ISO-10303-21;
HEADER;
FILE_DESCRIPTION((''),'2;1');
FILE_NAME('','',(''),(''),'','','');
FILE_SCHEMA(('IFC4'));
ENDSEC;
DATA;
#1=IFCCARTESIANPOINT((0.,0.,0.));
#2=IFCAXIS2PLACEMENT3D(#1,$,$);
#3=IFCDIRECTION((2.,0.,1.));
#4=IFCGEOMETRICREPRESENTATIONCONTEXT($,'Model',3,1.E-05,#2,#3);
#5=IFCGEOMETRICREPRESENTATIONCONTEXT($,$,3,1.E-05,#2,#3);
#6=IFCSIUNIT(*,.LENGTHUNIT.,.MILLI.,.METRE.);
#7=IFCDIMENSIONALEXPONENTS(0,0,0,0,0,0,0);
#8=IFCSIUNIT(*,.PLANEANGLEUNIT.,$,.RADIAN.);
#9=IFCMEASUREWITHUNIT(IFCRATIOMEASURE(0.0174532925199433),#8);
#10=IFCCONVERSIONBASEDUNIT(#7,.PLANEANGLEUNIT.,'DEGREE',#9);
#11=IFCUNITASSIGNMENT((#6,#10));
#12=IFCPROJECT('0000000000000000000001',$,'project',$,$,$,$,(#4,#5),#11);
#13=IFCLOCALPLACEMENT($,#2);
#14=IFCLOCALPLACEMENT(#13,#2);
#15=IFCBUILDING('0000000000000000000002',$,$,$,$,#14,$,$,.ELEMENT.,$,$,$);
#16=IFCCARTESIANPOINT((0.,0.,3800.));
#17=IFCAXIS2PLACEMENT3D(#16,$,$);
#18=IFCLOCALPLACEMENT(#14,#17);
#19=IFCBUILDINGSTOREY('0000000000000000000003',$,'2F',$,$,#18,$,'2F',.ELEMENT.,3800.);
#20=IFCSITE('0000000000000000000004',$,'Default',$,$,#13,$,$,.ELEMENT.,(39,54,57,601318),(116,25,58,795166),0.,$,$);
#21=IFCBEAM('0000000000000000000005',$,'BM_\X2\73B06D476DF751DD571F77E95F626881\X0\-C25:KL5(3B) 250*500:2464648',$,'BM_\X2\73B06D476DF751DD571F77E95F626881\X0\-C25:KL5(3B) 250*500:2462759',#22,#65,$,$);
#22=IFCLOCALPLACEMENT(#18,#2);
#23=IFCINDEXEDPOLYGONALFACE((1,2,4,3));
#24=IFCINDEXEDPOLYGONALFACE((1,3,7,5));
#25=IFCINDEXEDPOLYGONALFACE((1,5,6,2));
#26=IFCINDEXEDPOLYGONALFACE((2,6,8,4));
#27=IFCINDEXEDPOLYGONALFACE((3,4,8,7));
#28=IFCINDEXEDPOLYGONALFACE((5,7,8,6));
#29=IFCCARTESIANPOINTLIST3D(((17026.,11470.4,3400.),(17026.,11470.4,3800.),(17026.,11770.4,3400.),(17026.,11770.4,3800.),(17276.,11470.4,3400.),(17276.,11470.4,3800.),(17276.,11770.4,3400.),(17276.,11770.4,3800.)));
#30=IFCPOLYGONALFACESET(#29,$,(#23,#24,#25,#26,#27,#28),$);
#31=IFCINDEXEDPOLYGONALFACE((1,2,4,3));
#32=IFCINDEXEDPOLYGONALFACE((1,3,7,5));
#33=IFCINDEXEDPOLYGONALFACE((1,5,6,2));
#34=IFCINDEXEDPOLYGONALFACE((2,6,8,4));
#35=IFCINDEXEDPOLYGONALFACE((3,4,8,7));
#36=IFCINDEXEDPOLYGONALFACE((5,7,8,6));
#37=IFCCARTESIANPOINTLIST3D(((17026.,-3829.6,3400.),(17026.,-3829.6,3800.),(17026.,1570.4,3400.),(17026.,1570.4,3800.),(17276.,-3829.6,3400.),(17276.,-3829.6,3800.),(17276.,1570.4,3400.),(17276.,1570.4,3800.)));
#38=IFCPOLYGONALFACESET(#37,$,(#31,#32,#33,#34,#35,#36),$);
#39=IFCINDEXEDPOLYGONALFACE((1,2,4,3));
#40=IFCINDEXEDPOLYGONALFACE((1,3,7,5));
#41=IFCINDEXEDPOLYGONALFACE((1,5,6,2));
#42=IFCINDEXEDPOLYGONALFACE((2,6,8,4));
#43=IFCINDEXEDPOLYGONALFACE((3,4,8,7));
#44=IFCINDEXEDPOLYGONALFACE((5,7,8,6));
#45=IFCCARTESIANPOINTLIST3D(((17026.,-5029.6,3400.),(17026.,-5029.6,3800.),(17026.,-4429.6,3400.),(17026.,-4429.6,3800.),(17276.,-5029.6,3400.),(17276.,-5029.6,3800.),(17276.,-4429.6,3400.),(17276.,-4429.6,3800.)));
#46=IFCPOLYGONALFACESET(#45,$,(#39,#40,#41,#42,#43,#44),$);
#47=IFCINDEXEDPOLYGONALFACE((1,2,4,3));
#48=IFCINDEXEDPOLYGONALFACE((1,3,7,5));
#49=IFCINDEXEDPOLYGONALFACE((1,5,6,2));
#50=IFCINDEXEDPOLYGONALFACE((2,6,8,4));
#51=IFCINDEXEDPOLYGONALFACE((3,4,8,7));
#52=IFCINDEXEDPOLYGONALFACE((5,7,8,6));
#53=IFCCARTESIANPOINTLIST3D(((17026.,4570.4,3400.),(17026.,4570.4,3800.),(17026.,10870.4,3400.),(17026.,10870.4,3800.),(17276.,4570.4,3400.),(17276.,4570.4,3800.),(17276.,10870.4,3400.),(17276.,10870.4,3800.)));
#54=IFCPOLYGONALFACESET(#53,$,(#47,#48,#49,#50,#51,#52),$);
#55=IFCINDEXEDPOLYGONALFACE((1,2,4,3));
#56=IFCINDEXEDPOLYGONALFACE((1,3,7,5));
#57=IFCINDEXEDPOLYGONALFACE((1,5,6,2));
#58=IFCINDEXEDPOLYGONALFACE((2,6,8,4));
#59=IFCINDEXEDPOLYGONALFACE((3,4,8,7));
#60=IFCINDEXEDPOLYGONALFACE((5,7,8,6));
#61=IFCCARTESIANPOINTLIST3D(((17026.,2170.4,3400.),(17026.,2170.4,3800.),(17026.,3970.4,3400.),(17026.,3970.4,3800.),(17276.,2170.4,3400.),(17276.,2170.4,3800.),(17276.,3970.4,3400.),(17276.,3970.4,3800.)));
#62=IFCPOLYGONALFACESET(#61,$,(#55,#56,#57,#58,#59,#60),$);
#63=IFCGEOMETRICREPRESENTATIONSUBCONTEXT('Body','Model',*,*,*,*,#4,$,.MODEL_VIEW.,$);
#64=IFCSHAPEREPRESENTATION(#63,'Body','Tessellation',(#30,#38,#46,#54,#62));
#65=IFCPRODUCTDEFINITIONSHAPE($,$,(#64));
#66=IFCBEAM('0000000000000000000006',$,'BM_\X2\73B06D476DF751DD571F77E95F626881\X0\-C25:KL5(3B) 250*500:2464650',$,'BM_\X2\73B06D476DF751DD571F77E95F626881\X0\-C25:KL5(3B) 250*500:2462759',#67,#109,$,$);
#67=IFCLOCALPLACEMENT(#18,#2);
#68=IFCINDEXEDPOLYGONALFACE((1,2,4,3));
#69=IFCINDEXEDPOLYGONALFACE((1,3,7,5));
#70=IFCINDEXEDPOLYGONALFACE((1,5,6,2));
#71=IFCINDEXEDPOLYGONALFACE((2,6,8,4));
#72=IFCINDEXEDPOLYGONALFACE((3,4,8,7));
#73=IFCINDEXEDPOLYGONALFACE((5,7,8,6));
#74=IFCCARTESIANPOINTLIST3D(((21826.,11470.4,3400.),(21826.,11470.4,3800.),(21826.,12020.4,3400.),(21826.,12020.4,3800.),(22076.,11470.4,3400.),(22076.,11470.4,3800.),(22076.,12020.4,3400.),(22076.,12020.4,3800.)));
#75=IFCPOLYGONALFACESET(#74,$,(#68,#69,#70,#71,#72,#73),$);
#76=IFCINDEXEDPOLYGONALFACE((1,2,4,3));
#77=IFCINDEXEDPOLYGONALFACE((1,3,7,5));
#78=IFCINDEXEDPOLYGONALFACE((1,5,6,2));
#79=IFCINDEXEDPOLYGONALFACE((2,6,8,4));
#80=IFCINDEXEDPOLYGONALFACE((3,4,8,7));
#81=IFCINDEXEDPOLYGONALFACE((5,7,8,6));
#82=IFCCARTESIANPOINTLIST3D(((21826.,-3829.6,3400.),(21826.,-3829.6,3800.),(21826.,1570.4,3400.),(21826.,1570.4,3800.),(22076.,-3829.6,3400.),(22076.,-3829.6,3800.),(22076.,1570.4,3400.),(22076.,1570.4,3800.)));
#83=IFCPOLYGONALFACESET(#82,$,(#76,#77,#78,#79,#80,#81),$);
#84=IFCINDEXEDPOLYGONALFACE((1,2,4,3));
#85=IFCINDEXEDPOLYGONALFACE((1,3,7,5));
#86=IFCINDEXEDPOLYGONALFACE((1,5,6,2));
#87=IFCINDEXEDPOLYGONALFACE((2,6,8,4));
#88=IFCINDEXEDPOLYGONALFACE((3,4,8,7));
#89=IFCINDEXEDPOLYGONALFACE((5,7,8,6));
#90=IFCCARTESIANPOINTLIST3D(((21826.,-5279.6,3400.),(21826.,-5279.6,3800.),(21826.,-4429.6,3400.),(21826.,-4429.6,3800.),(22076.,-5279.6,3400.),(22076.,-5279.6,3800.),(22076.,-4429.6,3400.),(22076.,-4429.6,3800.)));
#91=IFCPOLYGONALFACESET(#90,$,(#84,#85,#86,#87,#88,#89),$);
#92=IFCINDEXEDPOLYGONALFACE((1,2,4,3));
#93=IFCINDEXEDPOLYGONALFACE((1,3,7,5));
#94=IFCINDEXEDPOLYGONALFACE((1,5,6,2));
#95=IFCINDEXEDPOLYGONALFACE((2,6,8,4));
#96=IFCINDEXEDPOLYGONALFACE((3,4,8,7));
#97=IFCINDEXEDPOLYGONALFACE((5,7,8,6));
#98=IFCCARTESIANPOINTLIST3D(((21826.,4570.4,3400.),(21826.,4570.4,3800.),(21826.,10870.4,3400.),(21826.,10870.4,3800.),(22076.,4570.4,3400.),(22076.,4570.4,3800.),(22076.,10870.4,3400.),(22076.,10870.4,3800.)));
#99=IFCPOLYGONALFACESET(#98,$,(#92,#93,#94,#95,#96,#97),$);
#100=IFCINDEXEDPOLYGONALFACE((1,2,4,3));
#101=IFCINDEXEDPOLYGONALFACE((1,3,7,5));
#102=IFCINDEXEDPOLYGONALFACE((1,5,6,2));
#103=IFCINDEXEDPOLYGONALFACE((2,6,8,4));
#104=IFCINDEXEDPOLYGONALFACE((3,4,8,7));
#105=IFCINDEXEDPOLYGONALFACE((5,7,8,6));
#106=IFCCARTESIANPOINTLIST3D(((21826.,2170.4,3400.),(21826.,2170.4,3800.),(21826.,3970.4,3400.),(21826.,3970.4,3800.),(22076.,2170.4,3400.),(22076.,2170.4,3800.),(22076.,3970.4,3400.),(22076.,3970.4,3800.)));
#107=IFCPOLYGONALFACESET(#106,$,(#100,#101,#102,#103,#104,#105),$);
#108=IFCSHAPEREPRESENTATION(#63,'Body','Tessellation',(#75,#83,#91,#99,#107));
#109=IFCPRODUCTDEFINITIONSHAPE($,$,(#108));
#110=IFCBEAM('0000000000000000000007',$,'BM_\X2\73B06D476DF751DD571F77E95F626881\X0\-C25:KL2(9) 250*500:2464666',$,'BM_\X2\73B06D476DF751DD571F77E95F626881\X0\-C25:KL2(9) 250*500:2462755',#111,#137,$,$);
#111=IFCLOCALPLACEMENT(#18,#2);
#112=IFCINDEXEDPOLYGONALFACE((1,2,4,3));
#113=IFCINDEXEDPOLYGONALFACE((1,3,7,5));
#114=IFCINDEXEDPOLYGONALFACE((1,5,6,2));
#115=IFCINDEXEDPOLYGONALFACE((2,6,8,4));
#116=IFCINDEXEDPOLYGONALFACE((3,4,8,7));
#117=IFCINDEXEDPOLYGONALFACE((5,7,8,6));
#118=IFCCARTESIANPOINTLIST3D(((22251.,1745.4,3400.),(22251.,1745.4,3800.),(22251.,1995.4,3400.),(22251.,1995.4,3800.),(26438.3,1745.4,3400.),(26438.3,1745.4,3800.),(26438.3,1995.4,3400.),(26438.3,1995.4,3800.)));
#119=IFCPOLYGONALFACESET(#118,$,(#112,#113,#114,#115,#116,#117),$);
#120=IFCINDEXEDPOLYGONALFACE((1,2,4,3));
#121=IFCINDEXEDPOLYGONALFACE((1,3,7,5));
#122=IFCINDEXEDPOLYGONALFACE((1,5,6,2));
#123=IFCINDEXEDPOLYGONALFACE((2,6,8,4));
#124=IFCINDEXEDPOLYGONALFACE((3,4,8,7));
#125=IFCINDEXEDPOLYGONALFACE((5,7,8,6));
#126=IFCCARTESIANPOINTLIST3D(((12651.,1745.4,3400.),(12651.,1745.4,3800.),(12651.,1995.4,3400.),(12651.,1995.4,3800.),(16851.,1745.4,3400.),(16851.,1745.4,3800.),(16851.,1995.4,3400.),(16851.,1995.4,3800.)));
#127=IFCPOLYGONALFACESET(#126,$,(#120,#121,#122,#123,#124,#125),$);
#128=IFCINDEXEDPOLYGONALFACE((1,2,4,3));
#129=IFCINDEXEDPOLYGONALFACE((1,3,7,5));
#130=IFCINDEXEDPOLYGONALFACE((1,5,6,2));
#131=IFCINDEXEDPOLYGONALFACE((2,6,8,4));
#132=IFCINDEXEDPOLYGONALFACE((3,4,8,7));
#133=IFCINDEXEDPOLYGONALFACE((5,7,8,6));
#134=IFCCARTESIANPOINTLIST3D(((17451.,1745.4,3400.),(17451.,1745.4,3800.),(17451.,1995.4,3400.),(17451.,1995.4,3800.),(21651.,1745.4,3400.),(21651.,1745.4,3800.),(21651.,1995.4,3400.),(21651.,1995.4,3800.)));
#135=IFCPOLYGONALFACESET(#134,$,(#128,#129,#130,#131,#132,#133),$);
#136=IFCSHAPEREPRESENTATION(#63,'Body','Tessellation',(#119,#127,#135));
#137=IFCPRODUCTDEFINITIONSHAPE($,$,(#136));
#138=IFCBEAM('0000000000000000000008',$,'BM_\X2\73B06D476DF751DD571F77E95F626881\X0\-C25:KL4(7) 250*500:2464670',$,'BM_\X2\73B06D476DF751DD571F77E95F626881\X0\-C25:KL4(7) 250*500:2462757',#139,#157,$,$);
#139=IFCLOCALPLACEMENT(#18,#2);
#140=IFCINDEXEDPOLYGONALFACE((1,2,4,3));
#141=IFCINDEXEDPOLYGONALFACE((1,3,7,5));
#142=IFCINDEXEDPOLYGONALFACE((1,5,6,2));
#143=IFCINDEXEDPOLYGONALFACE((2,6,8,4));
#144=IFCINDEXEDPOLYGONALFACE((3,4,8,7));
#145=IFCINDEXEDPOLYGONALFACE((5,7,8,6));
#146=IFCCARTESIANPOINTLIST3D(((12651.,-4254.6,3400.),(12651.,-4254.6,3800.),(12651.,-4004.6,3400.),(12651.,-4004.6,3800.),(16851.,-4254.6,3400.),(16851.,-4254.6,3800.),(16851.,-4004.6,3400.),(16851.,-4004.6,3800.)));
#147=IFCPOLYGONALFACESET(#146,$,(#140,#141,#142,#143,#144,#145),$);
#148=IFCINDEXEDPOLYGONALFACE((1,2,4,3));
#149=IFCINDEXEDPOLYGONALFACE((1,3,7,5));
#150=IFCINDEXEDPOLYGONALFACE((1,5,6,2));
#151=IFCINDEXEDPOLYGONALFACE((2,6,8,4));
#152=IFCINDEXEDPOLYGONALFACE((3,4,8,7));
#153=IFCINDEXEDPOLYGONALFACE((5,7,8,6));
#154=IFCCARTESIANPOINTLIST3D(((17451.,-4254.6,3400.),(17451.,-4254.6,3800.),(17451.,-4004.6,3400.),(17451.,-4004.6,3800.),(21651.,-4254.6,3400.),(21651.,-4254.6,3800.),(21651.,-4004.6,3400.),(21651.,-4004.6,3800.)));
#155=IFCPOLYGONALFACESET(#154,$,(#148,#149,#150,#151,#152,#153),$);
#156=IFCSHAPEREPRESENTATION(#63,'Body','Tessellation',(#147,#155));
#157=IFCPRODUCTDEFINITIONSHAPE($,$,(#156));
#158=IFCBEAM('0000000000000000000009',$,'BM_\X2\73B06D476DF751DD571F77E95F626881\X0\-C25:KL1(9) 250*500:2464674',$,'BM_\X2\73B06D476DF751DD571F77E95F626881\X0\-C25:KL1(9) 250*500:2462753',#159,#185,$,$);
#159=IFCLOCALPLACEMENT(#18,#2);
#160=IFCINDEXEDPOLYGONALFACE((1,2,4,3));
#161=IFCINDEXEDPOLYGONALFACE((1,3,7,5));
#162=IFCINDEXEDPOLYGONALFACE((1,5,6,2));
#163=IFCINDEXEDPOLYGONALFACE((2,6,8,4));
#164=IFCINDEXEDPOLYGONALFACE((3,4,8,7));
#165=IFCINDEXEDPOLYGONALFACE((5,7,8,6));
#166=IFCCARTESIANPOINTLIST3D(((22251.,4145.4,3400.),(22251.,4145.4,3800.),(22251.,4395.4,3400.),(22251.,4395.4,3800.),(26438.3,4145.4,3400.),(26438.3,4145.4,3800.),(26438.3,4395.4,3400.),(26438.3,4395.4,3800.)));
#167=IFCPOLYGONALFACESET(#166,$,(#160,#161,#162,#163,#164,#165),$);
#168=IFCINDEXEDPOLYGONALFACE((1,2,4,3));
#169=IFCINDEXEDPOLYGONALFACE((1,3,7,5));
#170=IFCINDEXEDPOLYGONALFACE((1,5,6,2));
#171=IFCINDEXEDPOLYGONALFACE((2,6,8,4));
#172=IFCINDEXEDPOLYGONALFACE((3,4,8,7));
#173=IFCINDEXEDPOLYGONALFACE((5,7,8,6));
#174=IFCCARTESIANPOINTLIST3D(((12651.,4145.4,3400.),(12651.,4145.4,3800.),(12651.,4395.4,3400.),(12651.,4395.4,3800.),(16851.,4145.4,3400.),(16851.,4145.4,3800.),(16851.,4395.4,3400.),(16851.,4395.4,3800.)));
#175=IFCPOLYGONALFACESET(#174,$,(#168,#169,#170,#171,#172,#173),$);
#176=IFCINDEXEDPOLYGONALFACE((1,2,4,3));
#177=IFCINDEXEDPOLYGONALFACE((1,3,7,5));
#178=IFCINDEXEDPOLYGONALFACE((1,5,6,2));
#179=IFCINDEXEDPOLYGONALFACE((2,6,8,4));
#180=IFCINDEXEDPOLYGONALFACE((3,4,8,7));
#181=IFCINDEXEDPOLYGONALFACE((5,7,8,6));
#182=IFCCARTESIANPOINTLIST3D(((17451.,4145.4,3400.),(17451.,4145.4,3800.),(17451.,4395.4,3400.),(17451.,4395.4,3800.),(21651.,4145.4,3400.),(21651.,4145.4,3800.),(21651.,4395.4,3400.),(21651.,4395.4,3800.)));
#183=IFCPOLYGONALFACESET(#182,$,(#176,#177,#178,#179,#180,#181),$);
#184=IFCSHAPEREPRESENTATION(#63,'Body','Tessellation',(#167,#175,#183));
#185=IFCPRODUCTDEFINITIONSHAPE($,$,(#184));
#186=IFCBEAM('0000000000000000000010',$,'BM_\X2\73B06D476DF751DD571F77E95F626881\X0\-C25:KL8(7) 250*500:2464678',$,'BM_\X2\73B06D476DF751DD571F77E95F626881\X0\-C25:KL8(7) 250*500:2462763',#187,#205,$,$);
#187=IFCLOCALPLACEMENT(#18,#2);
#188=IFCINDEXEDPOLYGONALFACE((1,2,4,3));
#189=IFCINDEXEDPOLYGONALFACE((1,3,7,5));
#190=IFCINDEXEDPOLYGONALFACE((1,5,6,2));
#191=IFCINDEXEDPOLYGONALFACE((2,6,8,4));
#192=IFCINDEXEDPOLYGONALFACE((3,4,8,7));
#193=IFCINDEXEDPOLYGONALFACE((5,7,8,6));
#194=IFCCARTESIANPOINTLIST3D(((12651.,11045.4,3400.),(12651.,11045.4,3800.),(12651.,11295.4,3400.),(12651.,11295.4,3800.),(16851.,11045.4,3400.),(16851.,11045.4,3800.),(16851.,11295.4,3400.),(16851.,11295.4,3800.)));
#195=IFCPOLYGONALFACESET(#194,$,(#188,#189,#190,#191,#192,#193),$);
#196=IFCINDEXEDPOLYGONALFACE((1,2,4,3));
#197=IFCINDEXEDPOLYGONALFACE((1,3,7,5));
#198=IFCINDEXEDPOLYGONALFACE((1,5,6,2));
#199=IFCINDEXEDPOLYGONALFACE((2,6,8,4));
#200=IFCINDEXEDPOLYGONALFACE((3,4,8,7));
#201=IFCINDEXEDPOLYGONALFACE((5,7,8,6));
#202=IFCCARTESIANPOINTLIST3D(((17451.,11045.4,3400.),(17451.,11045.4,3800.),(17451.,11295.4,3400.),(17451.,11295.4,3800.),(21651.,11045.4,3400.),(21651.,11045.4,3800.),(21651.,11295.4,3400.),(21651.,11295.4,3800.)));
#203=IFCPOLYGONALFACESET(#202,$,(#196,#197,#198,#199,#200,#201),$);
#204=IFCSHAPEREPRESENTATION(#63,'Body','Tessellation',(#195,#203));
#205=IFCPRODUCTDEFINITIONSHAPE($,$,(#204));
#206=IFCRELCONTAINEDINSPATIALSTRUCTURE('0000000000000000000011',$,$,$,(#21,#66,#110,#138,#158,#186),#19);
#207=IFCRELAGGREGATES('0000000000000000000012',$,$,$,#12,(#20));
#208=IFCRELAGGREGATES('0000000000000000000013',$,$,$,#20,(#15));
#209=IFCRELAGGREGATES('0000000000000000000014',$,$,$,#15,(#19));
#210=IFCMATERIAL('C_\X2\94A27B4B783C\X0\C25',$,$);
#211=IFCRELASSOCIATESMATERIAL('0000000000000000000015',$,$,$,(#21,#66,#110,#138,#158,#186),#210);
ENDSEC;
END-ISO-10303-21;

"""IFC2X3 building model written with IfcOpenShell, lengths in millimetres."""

from ifc_helpers import new_model, entity, si_unit, converted_unit, direction, frame, frame_2d, origin, place, context, subcontext, project, spatial, rectangle, extrude, material, element, save


model = new_model("IFC2X3")

# Units and contexts
model_context = context("Model", 3, precision=1e-05, world=origin(), true_north=direction((2.0, 0.0, 1.0)))
context_of_model = context(None, 3, precision=1e-05, world=origin(), true_north=direction((2.0, 0.0, 1.0)))
body_context = subcontext(model_context, "Body", "Model", "MODEL_VIEW")
ifc_project = project(units=[si_unit("LENGTHUNIT", "METRE", prefix="MILLI"), converted_unit("PLANEANGLEUNIT", "DEGREE", entity("IfcRatioMeasure", 0.0174532925199433), si_unit("PLANEANGLEUNIT", "RADIAN"), dimensions=[0, 0, 0, 0, 0, 0, 0])], contexts=[model_context, context_of_model])

# Site, building, storey
site_placement = place(None, origin())
site = spatial("IfcSite", under=ifc_project, at=site_placement, Name="Default", CompositionType="ELEMENT", RefLatitude=(39, 54, 57, 601318), RefLongitude=(116, 25, 58, 795166), RefElevation=0.0)
building_placement = place(site_placement, origin())
building = spatial("IfcBuilding", under=site, at=building_placement, CompositionType="ELEMENT")
storey_placement = place(building_placement, frame((0.0, 0.0, 3800.0)))
storey = spatial("IfcBuildingStorey", under=building, at=storey_placement, Name="2F", LongName="2F", CompositionType="ELEMENT", Elevation=3800.0)

# Beams
ifc_material_1 = material(Name="C_钢筋砼C25")
beam_1_placement = place(storey_placement, frame((17151.0, 11895.4, 3900.0), z_axis=(0.0, 0.0, 1.0), x_axis=(0.0, -1.0, 0.0)))
element("IfcBeam", 1, at=beam_1_placement, inside=storey, material=ifc_material_1, Name="BM_现浇混凝土矩形梁-C25:KL5(3B) 250*500:2464648", ObjectType="BM_现浇混凝土矩形梁-C25:KL5(3B) 250*500:2462759", context=body_context, shape_type="SweptSolid", body=[
    extrude(rectangle(XDim=400.0, YDim=250.0, at=frame_2d((0.0, 0.0), x_axis=(1.0, 0.0))), frame((125.0, 0.0, -300.0), z_axis=(1.0, 0.0, 0.0), x_axis=(0.0, 0.0, 1.0)), (0.0, 0.0, 1.0), 300.0),
    extrude(rectangle(XDim=400.0, YDim=250.0, at=frame_2d((0.0, 0.0), x_axis=(1.0, 0.0))), frame((10325.0, 0.0, -300.0), z_axis=(1.0, 0.0, 0.0), x_axis=(0.0, 0.0, 1.0)), (0.0, 0.0, 1.0), 5400.0),
    extrude(rectangle(XDim=400.0, YDim=250.0, at=frame_2d((0.0, 0.0), x_axis=(1.0, 0.0))), frame((16325.0, 0.0, -300.0), z_axis=(1.0, 0.0, 0.0), x_axis=(0.0, 0.0, 1.0)), (0.0, 0.0, 1.0), 600.0),
    extrude(rectangle(XDim=400.0, YDim=250.0, at=frame_2d((0.0, 0.0), x_axis=(1.0, 0.0))), frame((1025.0, 0.0, -300.0), z_axis=(1.0, 0.0, 0.0), x_axis=(0.0, 0.0, 1.0)), (0.0, 0.0, 1.0), 6300.0),
    extrude(rectangle(XDim=400.0, YDim=250.0, at=frame_2d((0.0, 0.0), x_axis=(1.0, 0.0))), frame((7925.0, 0.0, -300.0), z_axis=(1.0, 0.0, 0.0), x_axis=(0.0, 0.0, 1.0)), (0.0, 0.0, 1.0), 1800.0),
])
beam_2_placement = place(storey_placement, frame((21951.0, 11895.4, 3900.0), z_axis=(0.0, 0.0, 1.0), x_axis=(0.0, -1.0, 0.0)))
element("IfcBeam", 2, at=beam_2_placement, inside=storey, material=ifc_material_1, Name="BM_现浇混凝土矩形梁-C25:KL5(3B) 250*500:2464650", ObjectType="BM_现浇混凝土矩形梁-C25:KL5(3B) 250*500:2462759", context=body_context, shape_type="SweptSolid", body=[
    extrude(rectangle(XDim=400.0, YDim=250.0, at=frame_2d((0.0, 0.0), x_axis=(1.0, 0.0))), frame((-125.0, 0.0, -300.0), z_axis=(1.0, 0.0, 0.0), x_axis=(0.0, 0.0, 1.0)), (0.0, 0.0, 1.0), 550.0),
    extrude(rectangle(XDim=400.0, YDim=250.0, at=frame_2d((0.0, 0.0), x_axis=(1.0, 0.0))), frame((10325.0, 0.0, -300.0), z_axis=(1.0, 0.0, 0.0), x_axis=(0.0, 0.0, 1.0)), (0.0, 0.0, 1.0), 5400.0),
    extrude(rectangle(XDim=400.0, YDim=250.0, at=frame_2d((0.0, 0.0), x_axis=(1.0, 0.0))), frame((16325.0, 0.0, -300.0), z_axis=(1.0, 0.0, 0.0), x_axis=(0.0, 0.0, 1.0)), (0.0, 0.0, 1.0), 850.0),
    extrude(rectangle(XDim=400.0, YDim=250.0, at=frame_2d((0.0, 0.0), x_axis=(1.0, 0.0))), frame((1025.0, 0.0, -300.0), z_axis=(1.0, 0.0, 0.0), x_axis=(0.0, 0.0, 1.0)), (0.0, 0.0, 1.0), 6300.0),
    extrude(rectangle(XDim=400.0, YDim=250.0, at=frame_2d((0.0, 0.0), x_axis=(1.0, 0.0))), frame((7925.0, 0.0, -300.0), z_axis=(1.0, 0.0, 0.0), x_axis=(0.0, 0.0, 1.0)), (0.0, 0.0, 1.0), 1800.0),
])
beam_3_placement = place(storey_placement, frame((12351.0, 1870.4, 3900.0)))
element("IfcBeam", 3, at=beam_3_placement, inside=storey, material=ifc_material_1, Name="BM_现浇混凝土矩形梁-C25:KL2(9) 250*500:2464666", ObjectType="BM_现浇混凝土矩形梁-C25:KL2(9) 250*500:2462755", context=body_context, shape_type="SweptSolid", body=[
    extrude(rectangle(XDim=400.0, YDim=250.0, at=frame_2d((0.0, 0.0), x_axis=(1.0, 0.0))), frame((9900.0, 0.0, -300.0), z_axis=(1.0, 0.0, 0.0), x_axis=(0.0, 0.0, 1.0)), (0.0, 0.0, 1.0), 4187.3),
    extrude(rectangle(XDim=400.0, YDim=250.0, at=frame_2d((0.0, 0.0), x_axis=(1.0, 0.0))), frame((300.0, 0.0, -300.0), z_axis=(1.0, 0.0, 0.0), x_axis=(0.0, 0.0, 1.0)), (0.0, 0.0, 1.0), 4200.0),
    extrude(rectangle(XDim=400.0, YDim=250.0, at=frame_2d((0.0, 0.0), x_axis=(1.0, 0.0))), frame((5100.0, 0.0, -300.0), z_axis=(1.0, 0.0, 0.0), x_axis=(0.0, 0.0, 1.0)), (0.0, 0.0, 1.0), 4200.0),
])
beam_4_placement = place(storey_placement, frame((12351.0, -4129.6, 3900.0)))
element("IfcBeam", 4, at=beam_4_placement, inside=storey, material=ifc_material_1, Name="BM_现浇混凝土矩形梁-C25:KL4(7) 250*500:2464670", ObjectType="BM_现浇混凝土矩形梁-C25:KL4(7) 250*500:2462757", context=body_context, shape_type="SweptSolid", body=[
    extrude(rectangle(XDim=400.0, YDim=250.0, at=frame_2d((0.0, 0.0), x_axis=(1.0, 0.0))), frame((300.0, 0.0, -300.0), z_axis=(1.0, 0.0, 0.0), x_axis=(0.0, 0.0, 1.0)), (0.0, 0.0, 1.0), 4200.0),
    extrude(rectangle(XDim=400.0, YDim=250.0, at=frame_2d((0.0, 0.0), x_axis=(1.0, 0.0))), frame((5100.0, 0.0, -300.0), z_axis=(1.0, 0.0, 0.0), x_axis=(0.0, 0.0, 1.0)), (0.0, 0.0, 1.0), 4200.0),
])
beam_5_placement = place(storey_placement, frame((12351.0, 4270.4, 3900.0)))
element("IfcBeam", 5, at=beam_5_placement, inside=storey, material=ifc_material_1, Name="BM_现浇混凝土矩形梁-C25:KL1(9) 250*500:2464674", ObjectType="BM_现浇混凝土矩形梁-C25:KL1(9) 250*500:2462753", context=body_context, shape_type="SweptSolid", body=[
    extrude(rectangle(XDim=400.0, YDim=250.0, at=frame_2d((0.0, 0.0), x_axis=(1.0, 0.0))), frame((9900.0, 0.0, -300.0), z_axis=(1.0, 0.0, 0.0), x_axis=(0.0, 0.0, 1.0)), (0.0, 0.0, 1.0), 4187.3),
    extrude(rectangle(XDim=400.0, YDim=250.0, at=frame_2d((0.0, 0.0), x_axis=(1.0, 0.0))), frame((300.0, 0.0, -300.0), z_axis=(1.0, 0.0, 0.0), x_axis=(0.0, 0.0, 1.0)), (0.0, 0.0, 1.0), 4200.0),
    extrude(rectangle(XDim=400.0, YDim=250.0, at=frame_2d((0.0, 0.0), x_axis=(1.0, 0.0))), frame((5100.0, 0.0, -300.0), z_axis=(1.0, 0.0, 0.0), x_axis=(0.0, 0.0, 1.0)), (0.0, 0.0, 1.0), 4200.0),
])
beam_6_placement = place(storey_placement, frame((12351.0, 11170.4, 3900.0)))
element("IfcBeam", 6, at=beam_6_placement, inside=storey, material=ifc_material_1, Name="BM_现浇混凝土矩形梁-C25:KL8(7) 250*500:2464678", ObjectType="BM_现浇混凝土矩形梁-C25:KL8(7) 250*500:2462763", context=body_context, shape_type="SweptSolid", body=[
    extrude(rectangle(XDim=400.0, YDim=250.0, at=frame_2d((0.0, 0.0), x_axis=(1.0, 0.0))), frame((300.0, 0.0, -300.0), z_axis=(1.0, 0.0, 0.0), x_axis=(0.0, 0.0, 1.0)), (0.0, 0.0, 1.0), 4200.0),
    extrude(rectangle(XDim=400.0, YDim=250.0, at=frame_2d((0.0, 0.0), x_axis=(1.0, 0.0))), frame((5100.0, 0.0, -300.0), z_axis=(1.0, 0.0, 0.0), x_axis=(0.0, 0.0, 1.0)), (0.0, 0.0, 1.0), 4200.0),
])

save(model, "model.ifc")
